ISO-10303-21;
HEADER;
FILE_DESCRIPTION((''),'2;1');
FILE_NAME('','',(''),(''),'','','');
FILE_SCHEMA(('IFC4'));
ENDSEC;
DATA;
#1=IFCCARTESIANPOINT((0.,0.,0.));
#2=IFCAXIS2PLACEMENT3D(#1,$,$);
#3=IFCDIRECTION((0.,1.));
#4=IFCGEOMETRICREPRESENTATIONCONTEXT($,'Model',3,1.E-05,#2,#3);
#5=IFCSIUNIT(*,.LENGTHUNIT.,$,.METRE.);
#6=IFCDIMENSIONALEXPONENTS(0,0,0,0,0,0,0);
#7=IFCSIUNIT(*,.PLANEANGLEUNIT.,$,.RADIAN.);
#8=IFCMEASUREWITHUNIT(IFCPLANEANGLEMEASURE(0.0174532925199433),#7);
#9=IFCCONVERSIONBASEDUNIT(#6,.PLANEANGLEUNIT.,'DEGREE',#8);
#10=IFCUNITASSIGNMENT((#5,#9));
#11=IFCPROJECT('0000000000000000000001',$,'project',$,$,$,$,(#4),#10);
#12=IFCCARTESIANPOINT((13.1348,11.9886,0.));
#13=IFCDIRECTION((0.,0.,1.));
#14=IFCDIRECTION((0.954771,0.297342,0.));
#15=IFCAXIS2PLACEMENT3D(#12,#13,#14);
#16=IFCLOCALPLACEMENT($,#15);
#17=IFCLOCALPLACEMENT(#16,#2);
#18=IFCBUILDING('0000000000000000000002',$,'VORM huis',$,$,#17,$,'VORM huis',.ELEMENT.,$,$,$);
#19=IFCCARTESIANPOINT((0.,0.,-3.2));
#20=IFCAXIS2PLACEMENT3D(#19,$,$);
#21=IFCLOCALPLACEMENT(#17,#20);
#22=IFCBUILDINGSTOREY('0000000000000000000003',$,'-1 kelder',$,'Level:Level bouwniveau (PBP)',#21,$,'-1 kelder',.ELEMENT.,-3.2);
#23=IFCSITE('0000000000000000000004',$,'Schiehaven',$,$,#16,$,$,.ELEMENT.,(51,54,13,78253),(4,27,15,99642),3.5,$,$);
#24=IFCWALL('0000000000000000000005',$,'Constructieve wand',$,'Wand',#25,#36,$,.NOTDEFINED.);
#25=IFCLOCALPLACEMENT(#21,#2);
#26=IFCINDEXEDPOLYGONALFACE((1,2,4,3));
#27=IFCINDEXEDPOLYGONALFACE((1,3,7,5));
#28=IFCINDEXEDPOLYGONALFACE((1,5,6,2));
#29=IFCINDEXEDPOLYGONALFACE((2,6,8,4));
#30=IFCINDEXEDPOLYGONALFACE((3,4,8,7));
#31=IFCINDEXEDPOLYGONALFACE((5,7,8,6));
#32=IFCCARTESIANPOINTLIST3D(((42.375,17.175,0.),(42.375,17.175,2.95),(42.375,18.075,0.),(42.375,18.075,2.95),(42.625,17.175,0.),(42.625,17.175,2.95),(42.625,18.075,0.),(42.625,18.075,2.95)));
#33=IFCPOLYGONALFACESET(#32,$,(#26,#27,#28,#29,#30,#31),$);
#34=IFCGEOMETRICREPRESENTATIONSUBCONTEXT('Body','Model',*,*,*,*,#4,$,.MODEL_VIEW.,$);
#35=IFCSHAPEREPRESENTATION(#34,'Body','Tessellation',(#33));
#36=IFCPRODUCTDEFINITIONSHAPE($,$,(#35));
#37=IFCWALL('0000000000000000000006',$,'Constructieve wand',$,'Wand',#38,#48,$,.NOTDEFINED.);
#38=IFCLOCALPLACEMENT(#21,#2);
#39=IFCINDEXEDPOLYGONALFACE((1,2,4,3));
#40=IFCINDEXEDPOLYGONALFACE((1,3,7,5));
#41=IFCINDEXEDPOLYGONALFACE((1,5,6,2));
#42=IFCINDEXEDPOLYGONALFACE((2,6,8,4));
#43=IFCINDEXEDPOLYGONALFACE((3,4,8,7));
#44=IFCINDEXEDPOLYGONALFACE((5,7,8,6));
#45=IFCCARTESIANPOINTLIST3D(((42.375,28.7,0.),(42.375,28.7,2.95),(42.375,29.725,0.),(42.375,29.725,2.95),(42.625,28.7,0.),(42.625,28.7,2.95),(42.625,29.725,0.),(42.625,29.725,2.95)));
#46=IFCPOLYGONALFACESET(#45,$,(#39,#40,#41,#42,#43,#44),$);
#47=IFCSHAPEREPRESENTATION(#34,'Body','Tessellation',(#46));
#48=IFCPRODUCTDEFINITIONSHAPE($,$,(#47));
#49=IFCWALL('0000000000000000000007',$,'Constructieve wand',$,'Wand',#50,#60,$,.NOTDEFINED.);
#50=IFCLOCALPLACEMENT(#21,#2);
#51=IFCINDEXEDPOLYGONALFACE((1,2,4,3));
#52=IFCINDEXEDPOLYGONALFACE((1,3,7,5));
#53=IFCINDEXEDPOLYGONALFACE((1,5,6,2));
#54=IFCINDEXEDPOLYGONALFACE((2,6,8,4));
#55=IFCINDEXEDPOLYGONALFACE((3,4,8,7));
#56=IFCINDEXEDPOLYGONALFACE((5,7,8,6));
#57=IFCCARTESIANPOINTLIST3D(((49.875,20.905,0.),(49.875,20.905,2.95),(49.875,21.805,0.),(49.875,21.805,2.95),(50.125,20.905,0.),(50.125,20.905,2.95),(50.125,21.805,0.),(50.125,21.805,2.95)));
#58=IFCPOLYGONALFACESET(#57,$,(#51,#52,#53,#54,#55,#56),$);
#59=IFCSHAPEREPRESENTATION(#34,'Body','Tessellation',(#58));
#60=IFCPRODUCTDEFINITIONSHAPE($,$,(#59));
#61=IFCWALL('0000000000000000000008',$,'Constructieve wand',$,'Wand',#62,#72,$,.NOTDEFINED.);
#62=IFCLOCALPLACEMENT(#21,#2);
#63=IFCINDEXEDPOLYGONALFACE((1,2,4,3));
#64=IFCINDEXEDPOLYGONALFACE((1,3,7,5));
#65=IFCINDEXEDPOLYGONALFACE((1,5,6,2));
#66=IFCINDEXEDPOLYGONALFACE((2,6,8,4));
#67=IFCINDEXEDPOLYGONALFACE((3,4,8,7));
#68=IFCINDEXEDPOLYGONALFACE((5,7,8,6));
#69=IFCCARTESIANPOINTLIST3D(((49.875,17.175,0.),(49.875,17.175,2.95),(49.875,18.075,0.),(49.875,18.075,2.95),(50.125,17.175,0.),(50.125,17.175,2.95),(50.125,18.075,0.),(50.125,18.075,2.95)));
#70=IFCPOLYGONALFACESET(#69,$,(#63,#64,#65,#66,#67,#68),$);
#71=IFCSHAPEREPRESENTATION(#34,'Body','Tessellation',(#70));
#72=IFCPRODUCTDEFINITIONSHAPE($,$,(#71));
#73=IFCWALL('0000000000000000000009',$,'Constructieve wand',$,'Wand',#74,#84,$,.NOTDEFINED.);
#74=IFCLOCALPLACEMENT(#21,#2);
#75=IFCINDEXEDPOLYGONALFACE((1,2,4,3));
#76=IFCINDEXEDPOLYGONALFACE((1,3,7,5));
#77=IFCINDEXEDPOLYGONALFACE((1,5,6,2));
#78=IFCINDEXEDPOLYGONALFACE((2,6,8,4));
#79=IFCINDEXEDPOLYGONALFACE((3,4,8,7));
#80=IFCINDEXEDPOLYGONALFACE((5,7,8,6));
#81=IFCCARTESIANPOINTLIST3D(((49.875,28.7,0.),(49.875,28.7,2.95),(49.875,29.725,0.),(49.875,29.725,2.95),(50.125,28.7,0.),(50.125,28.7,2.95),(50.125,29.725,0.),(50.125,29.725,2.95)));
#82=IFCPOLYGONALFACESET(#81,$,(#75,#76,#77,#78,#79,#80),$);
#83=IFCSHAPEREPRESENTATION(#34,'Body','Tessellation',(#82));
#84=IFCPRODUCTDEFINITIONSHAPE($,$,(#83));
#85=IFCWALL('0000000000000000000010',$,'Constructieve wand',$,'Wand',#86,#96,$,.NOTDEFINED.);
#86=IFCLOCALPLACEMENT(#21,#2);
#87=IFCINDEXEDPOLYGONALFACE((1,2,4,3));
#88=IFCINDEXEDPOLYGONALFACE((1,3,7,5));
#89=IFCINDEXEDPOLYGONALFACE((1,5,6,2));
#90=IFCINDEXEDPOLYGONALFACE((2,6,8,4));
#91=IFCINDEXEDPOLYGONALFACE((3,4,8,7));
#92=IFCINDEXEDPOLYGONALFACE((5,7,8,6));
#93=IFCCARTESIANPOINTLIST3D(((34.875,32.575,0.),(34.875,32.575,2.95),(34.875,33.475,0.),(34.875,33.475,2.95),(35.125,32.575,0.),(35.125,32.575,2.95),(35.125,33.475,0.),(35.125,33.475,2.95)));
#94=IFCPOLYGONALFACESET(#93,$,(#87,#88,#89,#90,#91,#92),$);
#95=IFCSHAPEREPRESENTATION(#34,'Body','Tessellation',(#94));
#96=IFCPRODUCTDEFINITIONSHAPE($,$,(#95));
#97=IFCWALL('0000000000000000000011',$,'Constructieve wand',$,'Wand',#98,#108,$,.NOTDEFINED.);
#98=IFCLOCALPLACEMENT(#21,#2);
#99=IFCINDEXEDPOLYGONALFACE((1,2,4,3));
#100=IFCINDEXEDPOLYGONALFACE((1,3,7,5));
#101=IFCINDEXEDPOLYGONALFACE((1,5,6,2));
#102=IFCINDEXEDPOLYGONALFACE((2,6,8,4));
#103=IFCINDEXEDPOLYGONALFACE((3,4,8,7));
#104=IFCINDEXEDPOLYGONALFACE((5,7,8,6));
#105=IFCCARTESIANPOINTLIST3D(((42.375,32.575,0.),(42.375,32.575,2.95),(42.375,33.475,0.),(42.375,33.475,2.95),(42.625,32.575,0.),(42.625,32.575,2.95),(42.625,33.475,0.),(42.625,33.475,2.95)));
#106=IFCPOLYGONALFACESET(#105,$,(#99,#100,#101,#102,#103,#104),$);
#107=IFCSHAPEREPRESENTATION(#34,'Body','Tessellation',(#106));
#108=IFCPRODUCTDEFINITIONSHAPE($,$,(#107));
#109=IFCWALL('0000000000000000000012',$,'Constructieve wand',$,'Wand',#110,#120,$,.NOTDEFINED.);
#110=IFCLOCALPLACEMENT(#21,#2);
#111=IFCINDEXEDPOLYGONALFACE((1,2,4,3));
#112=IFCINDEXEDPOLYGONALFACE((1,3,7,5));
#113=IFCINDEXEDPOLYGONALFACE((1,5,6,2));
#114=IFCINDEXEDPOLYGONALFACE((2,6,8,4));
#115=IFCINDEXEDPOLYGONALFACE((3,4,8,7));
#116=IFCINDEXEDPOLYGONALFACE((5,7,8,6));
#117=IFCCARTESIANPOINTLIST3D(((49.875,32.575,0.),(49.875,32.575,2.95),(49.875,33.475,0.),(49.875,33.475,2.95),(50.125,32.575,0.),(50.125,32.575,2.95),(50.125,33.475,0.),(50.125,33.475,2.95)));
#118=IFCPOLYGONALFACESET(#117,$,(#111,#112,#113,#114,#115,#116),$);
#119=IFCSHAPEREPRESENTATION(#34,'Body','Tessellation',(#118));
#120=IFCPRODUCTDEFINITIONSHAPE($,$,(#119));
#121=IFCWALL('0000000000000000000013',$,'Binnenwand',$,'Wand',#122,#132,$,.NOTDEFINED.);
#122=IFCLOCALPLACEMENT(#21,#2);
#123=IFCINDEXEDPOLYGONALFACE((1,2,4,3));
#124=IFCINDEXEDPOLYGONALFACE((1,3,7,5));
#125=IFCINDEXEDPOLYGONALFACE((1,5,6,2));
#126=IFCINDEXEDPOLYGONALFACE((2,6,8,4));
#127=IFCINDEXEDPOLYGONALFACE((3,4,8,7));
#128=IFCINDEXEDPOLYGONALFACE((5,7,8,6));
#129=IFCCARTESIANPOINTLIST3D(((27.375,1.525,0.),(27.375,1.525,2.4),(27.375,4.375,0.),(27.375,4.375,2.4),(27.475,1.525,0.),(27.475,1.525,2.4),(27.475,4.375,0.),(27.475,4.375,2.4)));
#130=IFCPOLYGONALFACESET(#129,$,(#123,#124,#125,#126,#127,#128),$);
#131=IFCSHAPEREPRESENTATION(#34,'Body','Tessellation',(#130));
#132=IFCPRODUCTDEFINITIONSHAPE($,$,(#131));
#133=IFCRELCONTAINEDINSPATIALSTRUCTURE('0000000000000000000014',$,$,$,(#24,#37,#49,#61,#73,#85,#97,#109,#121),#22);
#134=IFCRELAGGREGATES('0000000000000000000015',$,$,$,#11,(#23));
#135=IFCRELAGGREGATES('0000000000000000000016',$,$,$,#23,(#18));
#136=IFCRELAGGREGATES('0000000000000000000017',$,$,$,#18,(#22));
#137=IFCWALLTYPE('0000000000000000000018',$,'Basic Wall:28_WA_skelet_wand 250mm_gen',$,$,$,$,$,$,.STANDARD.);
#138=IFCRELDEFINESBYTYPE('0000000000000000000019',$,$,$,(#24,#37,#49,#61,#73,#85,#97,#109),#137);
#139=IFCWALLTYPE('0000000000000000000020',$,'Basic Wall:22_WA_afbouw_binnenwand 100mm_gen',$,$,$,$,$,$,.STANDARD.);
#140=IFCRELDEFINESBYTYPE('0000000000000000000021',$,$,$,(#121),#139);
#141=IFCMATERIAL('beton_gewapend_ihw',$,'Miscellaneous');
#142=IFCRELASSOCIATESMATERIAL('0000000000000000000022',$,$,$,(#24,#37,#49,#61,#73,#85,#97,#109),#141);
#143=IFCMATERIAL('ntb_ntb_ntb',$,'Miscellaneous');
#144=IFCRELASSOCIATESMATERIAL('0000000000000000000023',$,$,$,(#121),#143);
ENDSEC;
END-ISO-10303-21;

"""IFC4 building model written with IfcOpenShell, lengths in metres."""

from ifc_helpers import new_model, entity, si_unit, converted_unit, direction, frame, origin, place, context, subcontext, project, spatial, indexed_curve, outline, extrude, material, type_object, element, save


model = new_model("IFC4")

# Units and contexts
model_context = context("Model", 3, precision=1e-05, world=origin(), true_north=direction((0.0, 1.0)))
body_context = subcontext(model_context, "Body", "Model", "MODEL_VIEW")
ifc_project = project(units=[si_unit("LENGTHUNIT", "METRE"), converted_unit("PLANEANGLEUNIT", "DEGREE", entity("IfcPlaneAngleMeasure", 0.0174532925199433), si_unit("PLANEANGLEUNIT", "RADIAN"), dimensions=[0, 0, 0, 0, 0, 0, 0])], contexts=[model_context])

# Site, building, storey
site_placement = place(None, frame((13.1348, 11.9886, 0.0), z_axis=(0.0, 0.0, 1.0), x_axis=(0.954771, 0.297342, 0.0)))
site = spatial("IfcSite", under=ifc_project, at=site_placement, Name="Schiehaven", CompositionType="ELEMENT", RefLatitude=(51, 54, 13, 78253), RefLongitude=(4, 27, 15, 99642), RefElevation=3.5)
building_placement = place(site_placement, origin())
building = spatial("IfcBuilding", under=site, at=building_placement, Name="VORM huis", LongName="VORM huis", CompositionType="ELEMENT")
storey_placement = place(building_placement, frame((0.0, 0.0, -3.2)))
storey = spatial("IfcBuildingStorey", under=building, at=storey_placement, Name="-1 kelder", ObjectType="Level:Level bouwniveau (PBP)", LongName="-1 kelder", CompositionType="ELEMENT", Elevation=-3.2)

# Walls
ifc_material_1 = material(Name="beton_gewapend_ihw", Category="Miscellaneous")
wall_type_1 = type_object("IfcWallType", Name="Basic Wall:28_WA_skelet_wand 250mm_gen", PredefinedType="STANDARD")
wall_1_placement = place(storey_placement, frame((42.5, 18.075, 0.0), z_axis=(0.0, 0.0, 1.0), x_axis=(0.0, -1.0, 0.0)))
element("IfcWall", 1, at=wall_1_placement, inside=storey, type_object=wall_type_1, material=ifc_material_1, Name="Constructieve wand", ObjectType="Wand", PredefinedType="NOTDEFINED", context=body_context, shape_type="SweptSolid", body=[
    extrude(outline(indexed_curve([(0.9, 0.125), (0.0, 0.125), (0.0, -0.125), (0.9, -0.125), (0.9, 0.125)], self_intersect=False)), origin(), (0.0, 0.0, 1.0), 2.95),
])
wall_2_placement = place(storey_placement, frame((42.5, 29.725, 0.0), z_axis=(0.0, 0.0, 1.0), x_axis=(0.0, -1.0, 0.0)))
element("IfcWall", 2, at=wall_2_placement, inside=storey, type_object=wall_type_1, material=ifc_material_1, Name="Constructieve wand", ObjectType="Wand", PredefinedType="NOTDEFINED", context=body_context, shape_type="SweptSolid", body=[
    extrude(outline(indexed_curve([(1.025, 0.125), (0.0, 0.125), (0.0, -0.125), (1.025, -0.125), (1.025, 0.125)], self_intersect=False)), origin(), (0.0, 0.0, 1.0), 2.95),
])
wall_3_placement = place(storey_placement, frame((50.0, 21.805, 0.0), z_axis=(0.0, 0.0, 1.0), x_axis=(0.0, -1.0, 0.0)))
element("IfcWall", 3, at=wall_3_placement, inside=storey, type_object=wall_type_1, material=ifc_material_1, Name="Constructieve wand", ObjectType="Wand", PredefinedType="NOTDEFINED", context=body_context, shape_type="SweptSolid", body=[
    extrude(outline(indexed_curve([(0.9, 0.125), (0.0, 0.125), (0.0, -0.125), (0.9, -0.125), (0.9, 0.125)], self_intersect=False)), origin(), (0.0, 0.0, 1.0), 2.95),
])
wall_4_placement = place(storey_placement, frame((50.0, 18.075, 0.0), z_axis=(0.0, 0.0, 1.0), x_axis=(0.0, -1.0, 0.0)))
element("IfcWall", 4, at=wall_4_placement, inside=storey, type_object=wall_type_1, material=ifc_material_1, Name="Constructieve wand", ObjectType="Wand", PredefinedType="NOTDEFINED", context=body_context, shape_type="SweptSolid", body=[
    extrude(outline(indexed_curve([(0.9, 0.125), (0.0, 0.125), (0.0, -0.125), (0.9, -0.125), (0.9, 0.125)], self_intersect=False)), origin(), (0.0, 0.0, 1.0), 2.95),
])
wall_5_placement = place(storey_placement, frame((50.0, 29.725, 0.0), z_axis=(0.0, 0.0, 1.0), x_axis=(0.0, -1.0, 0.0)))
element("IfcWall", 5, at=wall_5_placement, inside=storey, type_object=wall_type_1, material=ifc_material_1, Name="Constructieve wand", ObjectType="Wand", PredefinedType="NOTDEFINED", context=body_context, shape_type="SweptSolid", body=[
    extrude(outline(indexed_curve([(1.025, 0.125), (0.0, 0.125), (0.0, -0.125), (1.025, -0.125), (1.025, 0.125)], self_intersect=False)), origin(), (0.0, 0.0, 1.0), 2.95),
])
wall_6_placement = place(storey_placement, frame((35.0, 32.575, 0.0), z_axis=(0.0, 0.0, 1.0), x_axis=(0.0, 1.0, 0.0)))
element("IfcWall", 6, at=wall_6_placement, inside=storey, type_object=wall_type_1, material=ifc_material_1, Name="Constructieve wand", ObjectType="Wand", PredefinedType="NOTDEFINED", context=body_context, shape_type="SweptSolid", body=[
    extrude(outline(indexed_curve([(0.9, 0.125), (0.0, 0.125), (0.0, -0.125), (0.9, -0.125), (0.9, 0.125)], self_intersect=False)), origin(), (0.0, 0.0, 1.0), 2.95),
])
wall_7_placement = place(storey_placement, frame((42.5, 32.575, 0.0), z_axis=(0.0, 0.0, 1.0), x_axis=(0.0, 1.0, 0.0)))
element("IfcWall", 7, at=wall_7_placement, inside=storey, type_object=wall_type_1, material=ifc_material_1, Name="Constructieve wand", ObjectType="Wand", PredefinedType="NOTDEFINED", context=body_context, shape_type="SweptSolid", body=[
    extrude(outline(indexed_curve([(0.9, 0.125), (0.0, 0.125), (0.0, -0.125), (0.9, -0.125), (0.9, 0.125)], self_intersect=False)), origin(), (0.0, 0.0, 1.0), 2.95),
])
wall_8_placement = place(storey_placement, frame((50.0, 32.575, 0.0), z_axis=(0.0, 0.0, 1.0), x_axis=(0.0, 1.0, 0.0)))
element("IfcWall", 8, at=wall_8_placement, inside=storey, type_object=wall_type_1, material=ifc_material_1, Name="Constructieve wand", ObjectType="Wand", PredefinedType="NOTDEFINED", context=body_context, shape_type="SweptSolid", body=[
    extrude(outline(indexed_curve([(0.9, 0.125), (0.0, 0.125), (0.0, -0.125), (0.9, -0.125), (0.9, 0.125)], self_intersect=False)), origin(), (0.0, 0.0, 1.0), 2.95),
])
ifc_material_2 = material(Name="ntb_ntb_ntb", Category="Miscellaneous")
wall_type_2 = type_object("IfcWallType", Name="Basic Wall:22_WA_afbouw_binnenwand 100mm_gen", PredefinedType="STANDARD")
wall_9_placement = place(storey_placement, frame((27.425, 4.375, 0.0), z_axis=(0.0, 0.0, 1.0), x_axis=(0.0, -1.0, 0.0)))
element("IfcWall", 9, at=wall_9_placement, inside=storey, type_object=wall_type_2, material=ifc_material_2, Name="Binnenwand", ObjectType="Wand", PredefinedType="NOTDEFINED", context=body_context, shape_type="SweptSolid", body=[
    extrude(outline(indexed_curve([(2.85, 0.05), (0.0, 0.05), (0.0, -0.05), (2.85, -0.05), (2.85, 0.05)], self_intersect=False)), origin(), (0.0, 0.0, 1.0), 2.4),
])

save(model, "model.ifc")
